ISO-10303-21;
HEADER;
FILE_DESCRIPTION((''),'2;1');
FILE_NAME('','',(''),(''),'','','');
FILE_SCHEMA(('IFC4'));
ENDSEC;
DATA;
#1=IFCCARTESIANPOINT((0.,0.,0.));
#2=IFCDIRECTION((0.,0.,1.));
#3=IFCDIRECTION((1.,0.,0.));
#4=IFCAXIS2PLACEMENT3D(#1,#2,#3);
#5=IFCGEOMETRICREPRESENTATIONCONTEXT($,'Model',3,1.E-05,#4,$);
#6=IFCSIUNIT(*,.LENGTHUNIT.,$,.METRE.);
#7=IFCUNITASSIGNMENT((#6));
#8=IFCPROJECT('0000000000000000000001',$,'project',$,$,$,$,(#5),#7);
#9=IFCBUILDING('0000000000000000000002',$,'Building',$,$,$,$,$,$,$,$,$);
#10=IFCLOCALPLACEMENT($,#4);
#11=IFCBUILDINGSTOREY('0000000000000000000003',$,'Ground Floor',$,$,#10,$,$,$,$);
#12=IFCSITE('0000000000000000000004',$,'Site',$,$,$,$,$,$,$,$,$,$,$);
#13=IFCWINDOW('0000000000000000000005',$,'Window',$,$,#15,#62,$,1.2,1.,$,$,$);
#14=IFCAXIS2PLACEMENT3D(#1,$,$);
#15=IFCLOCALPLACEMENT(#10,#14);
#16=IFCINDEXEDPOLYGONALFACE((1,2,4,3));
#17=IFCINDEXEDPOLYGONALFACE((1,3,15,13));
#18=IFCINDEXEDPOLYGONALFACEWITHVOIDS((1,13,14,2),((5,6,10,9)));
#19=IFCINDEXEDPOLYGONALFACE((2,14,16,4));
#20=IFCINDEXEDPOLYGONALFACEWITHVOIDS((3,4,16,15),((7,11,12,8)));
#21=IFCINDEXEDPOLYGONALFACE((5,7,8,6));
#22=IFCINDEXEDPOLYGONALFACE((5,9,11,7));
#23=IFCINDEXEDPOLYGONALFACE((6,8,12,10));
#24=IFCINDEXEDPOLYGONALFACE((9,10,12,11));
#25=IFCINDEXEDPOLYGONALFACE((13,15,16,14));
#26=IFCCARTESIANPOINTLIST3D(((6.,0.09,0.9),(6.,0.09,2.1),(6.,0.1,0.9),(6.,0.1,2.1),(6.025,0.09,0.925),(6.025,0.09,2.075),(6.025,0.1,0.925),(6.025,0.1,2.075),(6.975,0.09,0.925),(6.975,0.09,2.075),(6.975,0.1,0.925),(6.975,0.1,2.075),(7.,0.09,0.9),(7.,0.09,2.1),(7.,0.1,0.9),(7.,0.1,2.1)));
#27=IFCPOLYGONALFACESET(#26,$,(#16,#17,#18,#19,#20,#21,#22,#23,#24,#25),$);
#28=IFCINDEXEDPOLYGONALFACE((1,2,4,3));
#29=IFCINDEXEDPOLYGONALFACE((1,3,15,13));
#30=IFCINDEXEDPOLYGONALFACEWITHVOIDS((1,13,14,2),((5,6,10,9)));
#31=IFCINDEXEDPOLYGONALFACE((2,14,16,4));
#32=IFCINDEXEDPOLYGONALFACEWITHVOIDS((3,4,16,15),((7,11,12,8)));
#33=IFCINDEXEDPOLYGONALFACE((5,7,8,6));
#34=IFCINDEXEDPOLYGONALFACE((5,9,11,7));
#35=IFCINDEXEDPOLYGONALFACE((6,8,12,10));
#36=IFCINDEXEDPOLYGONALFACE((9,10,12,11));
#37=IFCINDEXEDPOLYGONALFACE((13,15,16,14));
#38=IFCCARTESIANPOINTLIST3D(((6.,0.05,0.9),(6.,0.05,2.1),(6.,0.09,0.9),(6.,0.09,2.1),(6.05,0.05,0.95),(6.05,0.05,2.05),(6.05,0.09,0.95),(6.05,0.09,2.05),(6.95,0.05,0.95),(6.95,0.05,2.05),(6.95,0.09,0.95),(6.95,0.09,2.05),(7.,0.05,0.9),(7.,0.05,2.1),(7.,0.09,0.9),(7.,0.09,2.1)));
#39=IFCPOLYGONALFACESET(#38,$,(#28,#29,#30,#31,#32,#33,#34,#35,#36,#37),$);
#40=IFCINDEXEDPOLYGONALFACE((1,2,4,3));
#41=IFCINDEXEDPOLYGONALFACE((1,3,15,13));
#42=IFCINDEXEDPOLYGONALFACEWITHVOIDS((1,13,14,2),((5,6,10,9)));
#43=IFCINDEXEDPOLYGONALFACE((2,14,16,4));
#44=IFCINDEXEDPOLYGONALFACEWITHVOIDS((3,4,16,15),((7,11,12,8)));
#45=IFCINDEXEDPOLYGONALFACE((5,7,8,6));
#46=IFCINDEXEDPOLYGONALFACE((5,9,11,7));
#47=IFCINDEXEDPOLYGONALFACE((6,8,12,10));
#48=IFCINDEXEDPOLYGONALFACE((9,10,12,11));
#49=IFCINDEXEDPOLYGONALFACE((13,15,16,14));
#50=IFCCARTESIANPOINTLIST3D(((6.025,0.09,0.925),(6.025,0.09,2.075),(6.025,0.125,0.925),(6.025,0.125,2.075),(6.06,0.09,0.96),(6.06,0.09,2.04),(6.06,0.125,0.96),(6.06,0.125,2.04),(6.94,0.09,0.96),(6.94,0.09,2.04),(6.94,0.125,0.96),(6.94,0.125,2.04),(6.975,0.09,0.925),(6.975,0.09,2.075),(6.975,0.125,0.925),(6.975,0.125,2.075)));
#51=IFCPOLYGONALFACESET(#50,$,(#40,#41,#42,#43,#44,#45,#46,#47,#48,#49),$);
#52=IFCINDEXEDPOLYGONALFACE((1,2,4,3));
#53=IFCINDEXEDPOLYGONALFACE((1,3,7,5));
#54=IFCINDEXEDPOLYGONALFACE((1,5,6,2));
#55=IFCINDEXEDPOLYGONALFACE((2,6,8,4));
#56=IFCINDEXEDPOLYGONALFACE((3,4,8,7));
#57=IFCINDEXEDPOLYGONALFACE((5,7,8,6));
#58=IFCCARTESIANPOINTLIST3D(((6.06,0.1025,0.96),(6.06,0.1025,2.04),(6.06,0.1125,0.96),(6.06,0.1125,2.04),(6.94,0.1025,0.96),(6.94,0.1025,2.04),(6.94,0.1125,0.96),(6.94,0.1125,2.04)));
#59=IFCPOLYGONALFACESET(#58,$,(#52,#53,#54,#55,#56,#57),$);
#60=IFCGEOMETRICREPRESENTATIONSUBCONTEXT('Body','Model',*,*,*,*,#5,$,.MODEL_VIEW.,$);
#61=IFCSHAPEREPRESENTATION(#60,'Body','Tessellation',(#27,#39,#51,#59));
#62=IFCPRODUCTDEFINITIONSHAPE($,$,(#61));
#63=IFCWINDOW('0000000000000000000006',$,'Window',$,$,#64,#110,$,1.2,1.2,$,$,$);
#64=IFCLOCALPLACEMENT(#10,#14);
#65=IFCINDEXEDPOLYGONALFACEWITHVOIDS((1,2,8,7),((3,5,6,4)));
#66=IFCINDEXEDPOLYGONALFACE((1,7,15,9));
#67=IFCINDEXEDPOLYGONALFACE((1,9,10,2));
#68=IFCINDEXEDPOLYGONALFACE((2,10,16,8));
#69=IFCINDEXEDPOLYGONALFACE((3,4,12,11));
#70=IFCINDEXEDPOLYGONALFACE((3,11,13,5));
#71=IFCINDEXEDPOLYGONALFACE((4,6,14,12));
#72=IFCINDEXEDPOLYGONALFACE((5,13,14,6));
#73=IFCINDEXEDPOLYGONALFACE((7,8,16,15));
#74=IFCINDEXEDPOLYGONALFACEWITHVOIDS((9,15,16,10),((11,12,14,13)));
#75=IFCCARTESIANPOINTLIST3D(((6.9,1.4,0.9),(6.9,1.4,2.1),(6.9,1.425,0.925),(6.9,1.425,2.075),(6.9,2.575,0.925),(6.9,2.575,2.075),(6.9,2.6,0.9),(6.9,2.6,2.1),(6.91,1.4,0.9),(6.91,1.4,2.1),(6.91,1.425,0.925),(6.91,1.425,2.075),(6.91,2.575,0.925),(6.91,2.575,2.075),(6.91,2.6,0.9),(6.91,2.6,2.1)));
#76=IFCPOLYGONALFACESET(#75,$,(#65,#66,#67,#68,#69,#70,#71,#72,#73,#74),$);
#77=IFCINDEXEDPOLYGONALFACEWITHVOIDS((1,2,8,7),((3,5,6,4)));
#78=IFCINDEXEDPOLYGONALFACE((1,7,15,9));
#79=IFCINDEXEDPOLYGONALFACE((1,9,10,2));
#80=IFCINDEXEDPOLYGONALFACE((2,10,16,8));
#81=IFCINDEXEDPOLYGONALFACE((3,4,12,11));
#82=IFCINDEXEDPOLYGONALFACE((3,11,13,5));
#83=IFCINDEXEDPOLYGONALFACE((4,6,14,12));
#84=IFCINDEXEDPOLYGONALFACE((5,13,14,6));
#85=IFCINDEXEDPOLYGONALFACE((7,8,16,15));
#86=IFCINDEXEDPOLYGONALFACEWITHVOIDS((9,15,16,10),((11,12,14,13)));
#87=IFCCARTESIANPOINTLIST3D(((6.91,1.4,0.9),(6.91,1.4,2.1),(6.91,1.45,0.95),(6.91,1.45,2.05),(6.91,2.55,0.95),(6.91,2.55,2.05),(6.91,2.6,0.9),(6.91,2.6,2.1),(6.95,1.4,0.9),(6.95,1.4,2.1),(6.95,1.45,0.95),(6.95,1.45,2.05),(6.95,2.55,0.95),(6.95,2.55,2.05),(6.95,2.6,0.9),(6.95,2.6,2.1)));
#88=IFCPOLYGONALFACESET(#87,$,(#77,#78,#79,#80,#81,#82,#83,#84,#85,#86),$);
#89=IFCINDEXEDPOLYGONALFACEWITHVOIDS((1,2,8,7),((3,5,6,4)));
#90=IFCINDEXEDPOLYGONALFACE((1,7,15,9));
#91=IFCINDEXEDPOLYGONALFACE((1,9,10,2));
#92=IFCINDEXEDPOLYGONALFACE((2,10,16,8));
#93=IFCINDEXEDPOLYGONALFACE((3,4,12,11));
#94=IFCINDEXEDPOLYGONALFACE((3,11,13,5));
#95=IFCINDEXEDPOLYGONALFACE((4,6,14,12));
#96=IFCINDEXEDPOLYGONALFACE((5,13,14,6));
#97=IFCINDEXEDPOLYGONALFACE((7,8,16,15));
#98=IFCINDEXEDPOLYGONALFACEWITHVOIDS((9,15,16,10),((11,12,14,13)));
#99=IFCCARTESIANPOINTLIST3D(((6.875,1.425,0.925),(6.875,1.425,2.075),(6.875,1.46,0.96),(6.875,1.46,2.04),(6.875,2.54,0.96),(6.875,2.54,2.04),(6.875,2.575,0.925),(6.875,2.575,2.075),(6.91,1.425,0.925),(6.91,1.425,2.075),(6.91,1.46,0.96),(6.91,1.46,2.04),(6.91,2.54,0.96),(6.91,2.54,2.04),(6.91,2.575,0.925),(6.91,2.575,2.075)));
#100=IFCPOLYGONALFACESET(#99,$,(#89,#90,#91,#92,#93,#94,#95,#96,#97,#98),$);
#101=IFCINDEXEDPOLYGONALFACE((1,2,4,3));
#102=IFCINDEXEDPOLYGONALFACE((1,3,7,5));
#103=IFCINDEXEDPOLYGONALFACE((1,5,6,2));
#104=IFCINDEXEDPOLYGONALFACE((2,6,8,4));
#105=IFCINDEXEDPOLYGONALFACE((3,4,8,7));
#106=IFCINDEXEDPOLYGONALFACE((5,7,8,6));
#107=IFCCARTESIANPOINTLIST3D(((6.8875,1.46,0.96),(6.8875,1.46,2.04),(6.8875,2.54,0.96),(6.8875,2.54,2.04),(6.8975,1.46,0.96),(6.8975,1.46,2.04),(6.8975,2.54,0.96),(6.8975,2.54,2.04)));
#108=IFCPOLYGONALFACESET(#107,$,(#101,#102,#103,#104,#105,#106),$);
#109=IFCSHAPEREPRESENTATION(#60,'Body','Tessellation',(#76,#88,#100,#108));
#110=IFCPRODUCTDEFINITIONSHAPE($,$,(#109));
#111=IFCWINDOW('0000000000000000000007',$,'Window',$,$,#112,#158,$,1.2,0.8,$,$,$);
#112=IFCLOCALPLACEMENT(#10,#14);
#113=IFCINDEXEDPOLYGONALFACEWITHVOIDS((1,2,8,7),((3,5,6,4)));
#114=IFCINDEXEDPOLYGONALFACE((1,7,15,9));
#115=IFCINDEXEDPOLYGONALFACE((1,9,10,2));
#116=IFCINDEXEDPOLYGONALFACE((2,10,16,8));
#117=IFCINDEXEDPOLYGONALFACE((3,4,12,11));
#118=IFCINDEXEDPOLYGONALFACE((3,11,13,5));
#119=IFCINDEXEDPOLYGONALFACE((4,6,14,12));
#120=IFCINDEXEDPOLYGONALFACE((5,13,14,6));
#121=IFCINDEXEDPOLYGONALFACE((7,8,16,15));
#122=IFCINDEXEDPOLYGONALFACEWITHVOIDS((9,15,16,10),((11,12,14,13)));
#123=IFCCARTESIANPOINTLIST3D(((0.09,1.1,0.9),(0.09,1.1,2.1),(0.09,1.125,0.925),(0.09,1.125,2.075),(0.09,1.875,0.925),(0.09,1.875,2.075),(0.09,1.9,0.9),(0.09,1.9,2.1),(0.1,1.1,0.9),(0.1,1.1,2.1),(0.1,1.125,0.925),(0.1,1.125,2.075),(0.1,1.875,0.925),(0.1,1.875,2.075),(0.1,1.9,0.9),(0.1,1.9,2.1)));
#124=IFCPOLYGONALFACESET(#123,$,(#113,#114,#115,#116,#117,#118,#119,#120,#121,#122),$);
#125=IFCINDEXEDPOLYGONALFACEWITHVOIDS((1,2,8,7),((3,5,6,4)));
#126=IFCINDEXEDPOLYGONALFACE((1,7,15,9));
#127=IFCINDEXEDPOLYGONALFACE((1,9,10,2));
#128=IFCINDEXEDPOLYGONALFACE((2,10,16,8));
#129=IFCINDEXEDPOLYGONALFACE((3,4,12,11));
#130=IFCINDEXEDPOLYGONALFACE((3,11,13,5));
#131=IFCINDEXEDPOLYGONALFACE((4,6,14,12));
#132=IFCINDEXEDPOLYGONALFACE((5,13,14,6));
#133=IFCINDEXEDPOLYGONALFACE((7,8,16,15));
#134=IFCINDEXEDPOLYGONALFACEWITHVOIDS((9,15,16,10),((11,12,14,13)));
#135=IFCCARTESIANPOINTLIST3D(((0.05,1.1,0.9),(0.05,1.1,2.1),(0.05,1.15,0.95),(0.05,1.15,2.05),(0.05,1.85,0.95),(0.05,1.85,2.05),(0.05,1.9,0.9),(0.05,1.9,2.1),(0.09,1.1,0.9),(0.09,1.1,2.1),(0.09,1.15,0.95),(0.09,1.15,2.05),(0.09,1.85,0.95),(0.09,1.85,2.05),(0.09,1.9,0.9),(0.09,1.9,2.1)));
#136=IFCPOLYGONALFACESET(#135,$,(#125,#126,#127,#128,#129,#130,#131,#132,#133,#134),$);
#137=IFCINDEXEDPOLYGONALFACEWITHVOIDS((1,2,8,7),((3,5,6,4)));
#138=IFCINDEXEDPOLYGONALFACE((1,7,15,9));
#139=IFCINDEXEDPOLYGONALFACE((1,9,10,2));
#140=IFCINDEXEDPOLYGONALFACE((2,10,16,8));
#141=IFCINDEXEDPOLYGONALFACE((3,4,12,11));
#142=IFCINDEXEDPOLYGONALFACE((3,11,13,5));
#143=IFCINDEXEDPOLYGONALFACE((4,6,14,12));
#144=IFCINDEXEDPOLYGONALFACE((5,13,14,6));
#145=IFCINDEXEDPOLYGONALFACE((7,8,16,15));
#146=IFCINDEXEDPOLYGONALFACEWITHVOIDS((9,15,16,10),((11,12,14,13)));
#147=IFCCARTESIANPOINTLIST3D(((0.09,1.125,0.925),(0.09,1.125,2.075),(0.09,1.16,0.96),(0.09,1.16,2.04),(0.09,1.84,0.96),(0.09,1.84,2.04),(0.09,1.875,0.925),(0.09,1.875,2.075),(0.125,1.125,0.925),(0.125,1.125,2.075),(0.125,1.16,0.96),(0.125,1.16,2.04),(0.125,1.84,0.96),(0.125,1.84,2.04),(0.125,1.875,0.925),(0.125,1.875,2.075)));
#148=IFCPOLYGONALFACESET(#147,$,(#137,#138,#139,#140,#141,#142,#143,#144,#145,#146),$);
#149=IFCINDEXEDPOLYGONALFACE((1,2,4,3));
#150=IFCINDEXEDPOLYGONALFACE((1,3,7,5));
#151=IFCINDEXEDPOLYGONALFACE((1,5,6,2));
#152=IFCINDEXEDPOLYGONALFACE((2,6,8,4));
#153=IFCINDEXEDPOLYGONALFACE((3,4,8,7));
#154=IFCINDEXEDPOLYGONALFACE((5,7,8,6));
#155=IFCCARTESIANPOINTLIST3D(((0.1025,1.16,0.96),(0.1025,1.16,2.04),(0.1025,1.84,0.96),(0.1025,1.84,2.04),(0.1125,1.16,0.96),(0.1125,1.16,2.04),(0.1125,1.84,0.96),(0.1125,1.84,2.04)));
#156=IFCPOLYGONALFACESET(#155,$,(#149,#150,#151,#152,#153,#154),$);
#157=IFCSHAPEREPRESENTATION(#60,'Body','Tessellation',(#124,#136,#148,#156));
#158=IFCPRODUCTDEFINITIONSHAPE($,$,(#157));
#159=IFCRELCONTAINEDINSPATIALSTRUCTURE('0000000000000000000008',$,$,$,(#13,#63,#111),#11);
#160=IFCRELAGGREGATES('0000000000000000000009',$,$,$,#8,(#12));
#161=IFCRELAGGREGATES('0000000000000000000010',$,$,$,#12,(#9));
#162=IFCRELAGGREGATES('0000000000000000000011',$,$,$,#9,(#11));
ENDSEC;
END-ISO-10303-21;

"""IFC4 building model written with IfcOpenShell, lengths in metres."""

from ifc_helpers import new_model, si_unit, frame, origin_with_axes, place, context, subcontext, project, spatial, line, indexed_curve, outline, extrude, element, save


model = new_model("IFC4")

# Units and contexts
model_context = context("Model", 3, precision=1e-05, world=origin_with_axes())
body_context = subcontext(model_context, "Body", "Model", "MODEL_VIEW")
ifc_project = project(units=[si_unit("LENGTHUNIT", "METRE")], contexts=[model_context])

# Site, building, storey
site = spatial("IfcSite", under=ifc_project, Name="Site")
building = spatial("IfcBuilding", under=site, Name="Building")
storey_placement = place(None, origin_with_axes())
storey = spatial("IfcBuildingStorey", under=building, at=storey_placement, Name="Ground Floor")

# Windows
window_1_placement = place(storey_placement, frame((6.0, 0.0, 0.9), z_axis=(0.0, 0.0, 1.0), x_axis=(1.0, 0.0, 0.0)))
element("IfcWindow", 1, at=window_1_placement, inside=storey, Name="Window", OverallHeight=1.2, OverallWidth=1.0, context=body_context, shape_type="SweptSolid", body=[
    extrude(outline(indexed_curve([(0.0, 0.0), (1.0, 0.0), (1.0, 1.2), (0.0, 1.2)], segments=[line(1, 2, 3, 4, 1)]), holes=[indexed_curve([(0.025, 0.025), (0.975, 0.025), (0.975, 1.175), (0.025, 1.175)], segments=[line(1, 2, 3, 4, 1)])]), frame((0.0, 0.09, 0.0), z_axis=(0.0, -1.0, 0.0), x_axis=(1.0, 0.0, 0.0)), (0.0, 0.0, -1.0), 0.01),
    extrude(outline(indexed_curve([(0.0, 0.0), (1.0, 0.0), (1.0, 1.2), (0.0, 1.2)], segments=[line(1, 2, 3, 4, 1)]), holes=[indexed_curve([(0.05, 0.05), (0.95, 0.05), (0.95, 1.15), (0.05, 1.15)], segments=[line(1, 2, 3, 4, 1)])]), frame((0.0, 0.05, 0.0), z_axis=(0.0, -1.0, 0.0), x_axis=(1.0, 0.0, 0.0)), (0.0, 0.0, -1.0), 0.04),
    extrude(outline(indexed_curve([(0.0, 0.0), (0.95, 0.0), (0.95, 1.15), (0.0, 1.15)], segments=[line(1, 2, 3, 4, 1)]), holes=[indexed_curve([(0.035, 0.035), (0.915, 0.035), (0.915, 1.115), (0.035, 1.115)], segments=[line(1, 2, 3, 4, 1)])]), frame((0.025, 0.09, 0.025), z_axis=(0.0, -1.0, 0.0), x_axis=(1.0, 0.0, 0.0)), (0.0, 0.0, -1.0), 0.035),
    extrude(outline(indexed_curve([(0.035, 0.035), (0.915, 0.035), (0.915, 1.115), (0.035, 1.115)], segments=[line(1, 2, 3, 4, 1)])), frame((0.025, 0.1025, 0.025), z_axis=(0.0, -1.0, 0.0), x_axis=(1.0, 0.0, 0.0)), (0.0, 0.0, -1.0), 0.01),
])
window_2_placement = place(storey_placement, frame((7.0, 1.4, 0.9), z_axis=(0.0, 0.0, 1.0), x_axis=(0.0, 1.0, 0.0)))
element("IfcWindow", 2, at=window_2_placement, inside=storey, Name="Window", OverallHeight=1.2, OverallWidth=1.2, context=body_context, shape_type="SweptSolid", body=[
    extrude(outline(indexed_curve([(0.0, 0.0), (1.2, 0.0), (1.2, 1.2), (0.0, 1.2)], segments=[line(1, 2, 3, 4, 1)]), holes=[indexed_curve([(0.025, 0.025), (1.175, 0.025), (1.175, 1.175), (0.025, 1.175)], segments=[line(1, 2, 3, 4, 1)])]), frame((0.0, 0.09, 0.0), z_axis=(0.0, -1.0, 0.0), x_axis=(1.0, 0.0, 0.0)), (0.0, 0.0, -1.0), 0.01),
    extrude(outline(indexed_curve([(0.0, 0.0), (1.2, 0.0), (1.2, 1.2), (0.0, 1.2)], segments=[line(1, 2, 3, 4, 1)]), holes=[indexed_curve([(0.05, 0.05), (1.15, 0.05), (1.15, 1.15), (0.05, 1.15)], segments=[line(1, 2, 3, 4, 1)])]), frame((0.0, 0.05, 0.0), z_axis=(0.0, -1.0, 0.0), x_axis=(1.0, 0.0, 0.0)), (0.0, 0.0, -1.0), 0.04),
    extrude(outline(indexed_curve([(0.0, 0.0), (1.15, 0.0), (1.15, 1.15), (0.0, 1.15)], segments=[line(1, 2, 3, 4, 1)]), holes=[indexed_curve([(0.035, 0.035), (1.115, 0.035), (1.115, 1.115), (0.035, 1.115)], segments=[line(1, 2, 3, 4, 1)])]), frame((0.025, 0.09, 0.025), z_axis=(0.0, -1.0, 0.0), x_axis=(1.0, 0.0, 0.0)), (0.0, 0.0, -1.0), 0.035),
    extrude(outline(indexed_curve([(0.035, 0.035), (1.115, 0.035), (1.115, 1.115), (0.035, 1.115)], segments=[line(1, 2, 3, 4, 1)])), frame((0.025, 0.1025, 0.025), z_axis=(0.0, -1.0, 0.0), x_axis=(1.0, 0.0, 0.0)), (0.0, 0.0, -1.0), 0.01),
])
window_3_placement = place(storey_placement, frame((0.0, 1.9, 0.9), z_axis=(0.0, 0.0, 1.0), x_axis=(0.0, -1.0, 0.0)))
element("IfcWindow", 3, at=window_3_placement, inside=storey, Name="Window", OverallHeight=1.2, OverallWidth=0.8, context=body_context, shape_type="SweptSolid", body=[
    extrude(outline(indexed_curve([(0.0, 0.0), (0.8, 0.0), (0.8, 1.2), (0.0, 1.2)], segments=[line(1, 2, 3, 4, 1)]), holes=[indexed_curve([(0.025, 0.025), (0.775, 0.025), (0.775, 1.175), (0.025, 1.175)], segments=[line(1, 2, 3, 4, 1)])]), frame((0.0, 0.09, 0.0), z_axis=(0.0, -1.0, 0.0), x_axis=(1.0, 0.0, 0.0)), (0.0, 0.0, -1.0), 0.01),
    extrude(outline(indexed_curve([(0.0, 0.0), (0.8, 0.0), (0.8, 1.2), (0.0, 1.2)], segments=[line(1, 2, 3, 4, 1)]), holes=[indexed_curve([(0.05, 0.05), (0.75, 0.05), (0.75, 1.15), (0.05, 1.15)], segments=[line(1, 2, 3, 4, 1)])]), frame((0.0, 0.05, 0.0), z_axis=(0.0, -1.0, 0.0), x_axis=(1.0, 0.0, 0.0)), (0.0, 0.0, -1.0), 0.04),
    extrude(outline(indexed_curve([(0.0, 0.0), (0.75, 0.0), (0.75, 1.15), (0.0, 1.15)], segments=[line(1, 2, 3, 4, 1)]), holes=[indexed_curve([(0.035, 0.035), (0.715, 0.035), (0.715, 1.115), (0.035, 1.115)], segments=[line(1, 2, 3, 4, 1)])]), frame((0.025, 0.09, 0.025), z_axis=(0.0, -1.0, 0.0), x_axis=(1.0, 0.0, 0.0)), (0.0, 0.0, -1.0), 0.035),
    extrude(outline(indexed_curve([(0.035, 0.035), (0.715, 0.035), (0.715, 1.115), (0.035, 1.115)], segments=[line(1, 2, 3, 4, 1)])), frame((0.025, 0.1025, 0.025), z_axis=(0.0, -1.0, 0.0), x_axis=(1.0, 0.0, 0.0)), (0.0, 0.0, -1.0), 0.01),
])

save(model, "model.ifc")
